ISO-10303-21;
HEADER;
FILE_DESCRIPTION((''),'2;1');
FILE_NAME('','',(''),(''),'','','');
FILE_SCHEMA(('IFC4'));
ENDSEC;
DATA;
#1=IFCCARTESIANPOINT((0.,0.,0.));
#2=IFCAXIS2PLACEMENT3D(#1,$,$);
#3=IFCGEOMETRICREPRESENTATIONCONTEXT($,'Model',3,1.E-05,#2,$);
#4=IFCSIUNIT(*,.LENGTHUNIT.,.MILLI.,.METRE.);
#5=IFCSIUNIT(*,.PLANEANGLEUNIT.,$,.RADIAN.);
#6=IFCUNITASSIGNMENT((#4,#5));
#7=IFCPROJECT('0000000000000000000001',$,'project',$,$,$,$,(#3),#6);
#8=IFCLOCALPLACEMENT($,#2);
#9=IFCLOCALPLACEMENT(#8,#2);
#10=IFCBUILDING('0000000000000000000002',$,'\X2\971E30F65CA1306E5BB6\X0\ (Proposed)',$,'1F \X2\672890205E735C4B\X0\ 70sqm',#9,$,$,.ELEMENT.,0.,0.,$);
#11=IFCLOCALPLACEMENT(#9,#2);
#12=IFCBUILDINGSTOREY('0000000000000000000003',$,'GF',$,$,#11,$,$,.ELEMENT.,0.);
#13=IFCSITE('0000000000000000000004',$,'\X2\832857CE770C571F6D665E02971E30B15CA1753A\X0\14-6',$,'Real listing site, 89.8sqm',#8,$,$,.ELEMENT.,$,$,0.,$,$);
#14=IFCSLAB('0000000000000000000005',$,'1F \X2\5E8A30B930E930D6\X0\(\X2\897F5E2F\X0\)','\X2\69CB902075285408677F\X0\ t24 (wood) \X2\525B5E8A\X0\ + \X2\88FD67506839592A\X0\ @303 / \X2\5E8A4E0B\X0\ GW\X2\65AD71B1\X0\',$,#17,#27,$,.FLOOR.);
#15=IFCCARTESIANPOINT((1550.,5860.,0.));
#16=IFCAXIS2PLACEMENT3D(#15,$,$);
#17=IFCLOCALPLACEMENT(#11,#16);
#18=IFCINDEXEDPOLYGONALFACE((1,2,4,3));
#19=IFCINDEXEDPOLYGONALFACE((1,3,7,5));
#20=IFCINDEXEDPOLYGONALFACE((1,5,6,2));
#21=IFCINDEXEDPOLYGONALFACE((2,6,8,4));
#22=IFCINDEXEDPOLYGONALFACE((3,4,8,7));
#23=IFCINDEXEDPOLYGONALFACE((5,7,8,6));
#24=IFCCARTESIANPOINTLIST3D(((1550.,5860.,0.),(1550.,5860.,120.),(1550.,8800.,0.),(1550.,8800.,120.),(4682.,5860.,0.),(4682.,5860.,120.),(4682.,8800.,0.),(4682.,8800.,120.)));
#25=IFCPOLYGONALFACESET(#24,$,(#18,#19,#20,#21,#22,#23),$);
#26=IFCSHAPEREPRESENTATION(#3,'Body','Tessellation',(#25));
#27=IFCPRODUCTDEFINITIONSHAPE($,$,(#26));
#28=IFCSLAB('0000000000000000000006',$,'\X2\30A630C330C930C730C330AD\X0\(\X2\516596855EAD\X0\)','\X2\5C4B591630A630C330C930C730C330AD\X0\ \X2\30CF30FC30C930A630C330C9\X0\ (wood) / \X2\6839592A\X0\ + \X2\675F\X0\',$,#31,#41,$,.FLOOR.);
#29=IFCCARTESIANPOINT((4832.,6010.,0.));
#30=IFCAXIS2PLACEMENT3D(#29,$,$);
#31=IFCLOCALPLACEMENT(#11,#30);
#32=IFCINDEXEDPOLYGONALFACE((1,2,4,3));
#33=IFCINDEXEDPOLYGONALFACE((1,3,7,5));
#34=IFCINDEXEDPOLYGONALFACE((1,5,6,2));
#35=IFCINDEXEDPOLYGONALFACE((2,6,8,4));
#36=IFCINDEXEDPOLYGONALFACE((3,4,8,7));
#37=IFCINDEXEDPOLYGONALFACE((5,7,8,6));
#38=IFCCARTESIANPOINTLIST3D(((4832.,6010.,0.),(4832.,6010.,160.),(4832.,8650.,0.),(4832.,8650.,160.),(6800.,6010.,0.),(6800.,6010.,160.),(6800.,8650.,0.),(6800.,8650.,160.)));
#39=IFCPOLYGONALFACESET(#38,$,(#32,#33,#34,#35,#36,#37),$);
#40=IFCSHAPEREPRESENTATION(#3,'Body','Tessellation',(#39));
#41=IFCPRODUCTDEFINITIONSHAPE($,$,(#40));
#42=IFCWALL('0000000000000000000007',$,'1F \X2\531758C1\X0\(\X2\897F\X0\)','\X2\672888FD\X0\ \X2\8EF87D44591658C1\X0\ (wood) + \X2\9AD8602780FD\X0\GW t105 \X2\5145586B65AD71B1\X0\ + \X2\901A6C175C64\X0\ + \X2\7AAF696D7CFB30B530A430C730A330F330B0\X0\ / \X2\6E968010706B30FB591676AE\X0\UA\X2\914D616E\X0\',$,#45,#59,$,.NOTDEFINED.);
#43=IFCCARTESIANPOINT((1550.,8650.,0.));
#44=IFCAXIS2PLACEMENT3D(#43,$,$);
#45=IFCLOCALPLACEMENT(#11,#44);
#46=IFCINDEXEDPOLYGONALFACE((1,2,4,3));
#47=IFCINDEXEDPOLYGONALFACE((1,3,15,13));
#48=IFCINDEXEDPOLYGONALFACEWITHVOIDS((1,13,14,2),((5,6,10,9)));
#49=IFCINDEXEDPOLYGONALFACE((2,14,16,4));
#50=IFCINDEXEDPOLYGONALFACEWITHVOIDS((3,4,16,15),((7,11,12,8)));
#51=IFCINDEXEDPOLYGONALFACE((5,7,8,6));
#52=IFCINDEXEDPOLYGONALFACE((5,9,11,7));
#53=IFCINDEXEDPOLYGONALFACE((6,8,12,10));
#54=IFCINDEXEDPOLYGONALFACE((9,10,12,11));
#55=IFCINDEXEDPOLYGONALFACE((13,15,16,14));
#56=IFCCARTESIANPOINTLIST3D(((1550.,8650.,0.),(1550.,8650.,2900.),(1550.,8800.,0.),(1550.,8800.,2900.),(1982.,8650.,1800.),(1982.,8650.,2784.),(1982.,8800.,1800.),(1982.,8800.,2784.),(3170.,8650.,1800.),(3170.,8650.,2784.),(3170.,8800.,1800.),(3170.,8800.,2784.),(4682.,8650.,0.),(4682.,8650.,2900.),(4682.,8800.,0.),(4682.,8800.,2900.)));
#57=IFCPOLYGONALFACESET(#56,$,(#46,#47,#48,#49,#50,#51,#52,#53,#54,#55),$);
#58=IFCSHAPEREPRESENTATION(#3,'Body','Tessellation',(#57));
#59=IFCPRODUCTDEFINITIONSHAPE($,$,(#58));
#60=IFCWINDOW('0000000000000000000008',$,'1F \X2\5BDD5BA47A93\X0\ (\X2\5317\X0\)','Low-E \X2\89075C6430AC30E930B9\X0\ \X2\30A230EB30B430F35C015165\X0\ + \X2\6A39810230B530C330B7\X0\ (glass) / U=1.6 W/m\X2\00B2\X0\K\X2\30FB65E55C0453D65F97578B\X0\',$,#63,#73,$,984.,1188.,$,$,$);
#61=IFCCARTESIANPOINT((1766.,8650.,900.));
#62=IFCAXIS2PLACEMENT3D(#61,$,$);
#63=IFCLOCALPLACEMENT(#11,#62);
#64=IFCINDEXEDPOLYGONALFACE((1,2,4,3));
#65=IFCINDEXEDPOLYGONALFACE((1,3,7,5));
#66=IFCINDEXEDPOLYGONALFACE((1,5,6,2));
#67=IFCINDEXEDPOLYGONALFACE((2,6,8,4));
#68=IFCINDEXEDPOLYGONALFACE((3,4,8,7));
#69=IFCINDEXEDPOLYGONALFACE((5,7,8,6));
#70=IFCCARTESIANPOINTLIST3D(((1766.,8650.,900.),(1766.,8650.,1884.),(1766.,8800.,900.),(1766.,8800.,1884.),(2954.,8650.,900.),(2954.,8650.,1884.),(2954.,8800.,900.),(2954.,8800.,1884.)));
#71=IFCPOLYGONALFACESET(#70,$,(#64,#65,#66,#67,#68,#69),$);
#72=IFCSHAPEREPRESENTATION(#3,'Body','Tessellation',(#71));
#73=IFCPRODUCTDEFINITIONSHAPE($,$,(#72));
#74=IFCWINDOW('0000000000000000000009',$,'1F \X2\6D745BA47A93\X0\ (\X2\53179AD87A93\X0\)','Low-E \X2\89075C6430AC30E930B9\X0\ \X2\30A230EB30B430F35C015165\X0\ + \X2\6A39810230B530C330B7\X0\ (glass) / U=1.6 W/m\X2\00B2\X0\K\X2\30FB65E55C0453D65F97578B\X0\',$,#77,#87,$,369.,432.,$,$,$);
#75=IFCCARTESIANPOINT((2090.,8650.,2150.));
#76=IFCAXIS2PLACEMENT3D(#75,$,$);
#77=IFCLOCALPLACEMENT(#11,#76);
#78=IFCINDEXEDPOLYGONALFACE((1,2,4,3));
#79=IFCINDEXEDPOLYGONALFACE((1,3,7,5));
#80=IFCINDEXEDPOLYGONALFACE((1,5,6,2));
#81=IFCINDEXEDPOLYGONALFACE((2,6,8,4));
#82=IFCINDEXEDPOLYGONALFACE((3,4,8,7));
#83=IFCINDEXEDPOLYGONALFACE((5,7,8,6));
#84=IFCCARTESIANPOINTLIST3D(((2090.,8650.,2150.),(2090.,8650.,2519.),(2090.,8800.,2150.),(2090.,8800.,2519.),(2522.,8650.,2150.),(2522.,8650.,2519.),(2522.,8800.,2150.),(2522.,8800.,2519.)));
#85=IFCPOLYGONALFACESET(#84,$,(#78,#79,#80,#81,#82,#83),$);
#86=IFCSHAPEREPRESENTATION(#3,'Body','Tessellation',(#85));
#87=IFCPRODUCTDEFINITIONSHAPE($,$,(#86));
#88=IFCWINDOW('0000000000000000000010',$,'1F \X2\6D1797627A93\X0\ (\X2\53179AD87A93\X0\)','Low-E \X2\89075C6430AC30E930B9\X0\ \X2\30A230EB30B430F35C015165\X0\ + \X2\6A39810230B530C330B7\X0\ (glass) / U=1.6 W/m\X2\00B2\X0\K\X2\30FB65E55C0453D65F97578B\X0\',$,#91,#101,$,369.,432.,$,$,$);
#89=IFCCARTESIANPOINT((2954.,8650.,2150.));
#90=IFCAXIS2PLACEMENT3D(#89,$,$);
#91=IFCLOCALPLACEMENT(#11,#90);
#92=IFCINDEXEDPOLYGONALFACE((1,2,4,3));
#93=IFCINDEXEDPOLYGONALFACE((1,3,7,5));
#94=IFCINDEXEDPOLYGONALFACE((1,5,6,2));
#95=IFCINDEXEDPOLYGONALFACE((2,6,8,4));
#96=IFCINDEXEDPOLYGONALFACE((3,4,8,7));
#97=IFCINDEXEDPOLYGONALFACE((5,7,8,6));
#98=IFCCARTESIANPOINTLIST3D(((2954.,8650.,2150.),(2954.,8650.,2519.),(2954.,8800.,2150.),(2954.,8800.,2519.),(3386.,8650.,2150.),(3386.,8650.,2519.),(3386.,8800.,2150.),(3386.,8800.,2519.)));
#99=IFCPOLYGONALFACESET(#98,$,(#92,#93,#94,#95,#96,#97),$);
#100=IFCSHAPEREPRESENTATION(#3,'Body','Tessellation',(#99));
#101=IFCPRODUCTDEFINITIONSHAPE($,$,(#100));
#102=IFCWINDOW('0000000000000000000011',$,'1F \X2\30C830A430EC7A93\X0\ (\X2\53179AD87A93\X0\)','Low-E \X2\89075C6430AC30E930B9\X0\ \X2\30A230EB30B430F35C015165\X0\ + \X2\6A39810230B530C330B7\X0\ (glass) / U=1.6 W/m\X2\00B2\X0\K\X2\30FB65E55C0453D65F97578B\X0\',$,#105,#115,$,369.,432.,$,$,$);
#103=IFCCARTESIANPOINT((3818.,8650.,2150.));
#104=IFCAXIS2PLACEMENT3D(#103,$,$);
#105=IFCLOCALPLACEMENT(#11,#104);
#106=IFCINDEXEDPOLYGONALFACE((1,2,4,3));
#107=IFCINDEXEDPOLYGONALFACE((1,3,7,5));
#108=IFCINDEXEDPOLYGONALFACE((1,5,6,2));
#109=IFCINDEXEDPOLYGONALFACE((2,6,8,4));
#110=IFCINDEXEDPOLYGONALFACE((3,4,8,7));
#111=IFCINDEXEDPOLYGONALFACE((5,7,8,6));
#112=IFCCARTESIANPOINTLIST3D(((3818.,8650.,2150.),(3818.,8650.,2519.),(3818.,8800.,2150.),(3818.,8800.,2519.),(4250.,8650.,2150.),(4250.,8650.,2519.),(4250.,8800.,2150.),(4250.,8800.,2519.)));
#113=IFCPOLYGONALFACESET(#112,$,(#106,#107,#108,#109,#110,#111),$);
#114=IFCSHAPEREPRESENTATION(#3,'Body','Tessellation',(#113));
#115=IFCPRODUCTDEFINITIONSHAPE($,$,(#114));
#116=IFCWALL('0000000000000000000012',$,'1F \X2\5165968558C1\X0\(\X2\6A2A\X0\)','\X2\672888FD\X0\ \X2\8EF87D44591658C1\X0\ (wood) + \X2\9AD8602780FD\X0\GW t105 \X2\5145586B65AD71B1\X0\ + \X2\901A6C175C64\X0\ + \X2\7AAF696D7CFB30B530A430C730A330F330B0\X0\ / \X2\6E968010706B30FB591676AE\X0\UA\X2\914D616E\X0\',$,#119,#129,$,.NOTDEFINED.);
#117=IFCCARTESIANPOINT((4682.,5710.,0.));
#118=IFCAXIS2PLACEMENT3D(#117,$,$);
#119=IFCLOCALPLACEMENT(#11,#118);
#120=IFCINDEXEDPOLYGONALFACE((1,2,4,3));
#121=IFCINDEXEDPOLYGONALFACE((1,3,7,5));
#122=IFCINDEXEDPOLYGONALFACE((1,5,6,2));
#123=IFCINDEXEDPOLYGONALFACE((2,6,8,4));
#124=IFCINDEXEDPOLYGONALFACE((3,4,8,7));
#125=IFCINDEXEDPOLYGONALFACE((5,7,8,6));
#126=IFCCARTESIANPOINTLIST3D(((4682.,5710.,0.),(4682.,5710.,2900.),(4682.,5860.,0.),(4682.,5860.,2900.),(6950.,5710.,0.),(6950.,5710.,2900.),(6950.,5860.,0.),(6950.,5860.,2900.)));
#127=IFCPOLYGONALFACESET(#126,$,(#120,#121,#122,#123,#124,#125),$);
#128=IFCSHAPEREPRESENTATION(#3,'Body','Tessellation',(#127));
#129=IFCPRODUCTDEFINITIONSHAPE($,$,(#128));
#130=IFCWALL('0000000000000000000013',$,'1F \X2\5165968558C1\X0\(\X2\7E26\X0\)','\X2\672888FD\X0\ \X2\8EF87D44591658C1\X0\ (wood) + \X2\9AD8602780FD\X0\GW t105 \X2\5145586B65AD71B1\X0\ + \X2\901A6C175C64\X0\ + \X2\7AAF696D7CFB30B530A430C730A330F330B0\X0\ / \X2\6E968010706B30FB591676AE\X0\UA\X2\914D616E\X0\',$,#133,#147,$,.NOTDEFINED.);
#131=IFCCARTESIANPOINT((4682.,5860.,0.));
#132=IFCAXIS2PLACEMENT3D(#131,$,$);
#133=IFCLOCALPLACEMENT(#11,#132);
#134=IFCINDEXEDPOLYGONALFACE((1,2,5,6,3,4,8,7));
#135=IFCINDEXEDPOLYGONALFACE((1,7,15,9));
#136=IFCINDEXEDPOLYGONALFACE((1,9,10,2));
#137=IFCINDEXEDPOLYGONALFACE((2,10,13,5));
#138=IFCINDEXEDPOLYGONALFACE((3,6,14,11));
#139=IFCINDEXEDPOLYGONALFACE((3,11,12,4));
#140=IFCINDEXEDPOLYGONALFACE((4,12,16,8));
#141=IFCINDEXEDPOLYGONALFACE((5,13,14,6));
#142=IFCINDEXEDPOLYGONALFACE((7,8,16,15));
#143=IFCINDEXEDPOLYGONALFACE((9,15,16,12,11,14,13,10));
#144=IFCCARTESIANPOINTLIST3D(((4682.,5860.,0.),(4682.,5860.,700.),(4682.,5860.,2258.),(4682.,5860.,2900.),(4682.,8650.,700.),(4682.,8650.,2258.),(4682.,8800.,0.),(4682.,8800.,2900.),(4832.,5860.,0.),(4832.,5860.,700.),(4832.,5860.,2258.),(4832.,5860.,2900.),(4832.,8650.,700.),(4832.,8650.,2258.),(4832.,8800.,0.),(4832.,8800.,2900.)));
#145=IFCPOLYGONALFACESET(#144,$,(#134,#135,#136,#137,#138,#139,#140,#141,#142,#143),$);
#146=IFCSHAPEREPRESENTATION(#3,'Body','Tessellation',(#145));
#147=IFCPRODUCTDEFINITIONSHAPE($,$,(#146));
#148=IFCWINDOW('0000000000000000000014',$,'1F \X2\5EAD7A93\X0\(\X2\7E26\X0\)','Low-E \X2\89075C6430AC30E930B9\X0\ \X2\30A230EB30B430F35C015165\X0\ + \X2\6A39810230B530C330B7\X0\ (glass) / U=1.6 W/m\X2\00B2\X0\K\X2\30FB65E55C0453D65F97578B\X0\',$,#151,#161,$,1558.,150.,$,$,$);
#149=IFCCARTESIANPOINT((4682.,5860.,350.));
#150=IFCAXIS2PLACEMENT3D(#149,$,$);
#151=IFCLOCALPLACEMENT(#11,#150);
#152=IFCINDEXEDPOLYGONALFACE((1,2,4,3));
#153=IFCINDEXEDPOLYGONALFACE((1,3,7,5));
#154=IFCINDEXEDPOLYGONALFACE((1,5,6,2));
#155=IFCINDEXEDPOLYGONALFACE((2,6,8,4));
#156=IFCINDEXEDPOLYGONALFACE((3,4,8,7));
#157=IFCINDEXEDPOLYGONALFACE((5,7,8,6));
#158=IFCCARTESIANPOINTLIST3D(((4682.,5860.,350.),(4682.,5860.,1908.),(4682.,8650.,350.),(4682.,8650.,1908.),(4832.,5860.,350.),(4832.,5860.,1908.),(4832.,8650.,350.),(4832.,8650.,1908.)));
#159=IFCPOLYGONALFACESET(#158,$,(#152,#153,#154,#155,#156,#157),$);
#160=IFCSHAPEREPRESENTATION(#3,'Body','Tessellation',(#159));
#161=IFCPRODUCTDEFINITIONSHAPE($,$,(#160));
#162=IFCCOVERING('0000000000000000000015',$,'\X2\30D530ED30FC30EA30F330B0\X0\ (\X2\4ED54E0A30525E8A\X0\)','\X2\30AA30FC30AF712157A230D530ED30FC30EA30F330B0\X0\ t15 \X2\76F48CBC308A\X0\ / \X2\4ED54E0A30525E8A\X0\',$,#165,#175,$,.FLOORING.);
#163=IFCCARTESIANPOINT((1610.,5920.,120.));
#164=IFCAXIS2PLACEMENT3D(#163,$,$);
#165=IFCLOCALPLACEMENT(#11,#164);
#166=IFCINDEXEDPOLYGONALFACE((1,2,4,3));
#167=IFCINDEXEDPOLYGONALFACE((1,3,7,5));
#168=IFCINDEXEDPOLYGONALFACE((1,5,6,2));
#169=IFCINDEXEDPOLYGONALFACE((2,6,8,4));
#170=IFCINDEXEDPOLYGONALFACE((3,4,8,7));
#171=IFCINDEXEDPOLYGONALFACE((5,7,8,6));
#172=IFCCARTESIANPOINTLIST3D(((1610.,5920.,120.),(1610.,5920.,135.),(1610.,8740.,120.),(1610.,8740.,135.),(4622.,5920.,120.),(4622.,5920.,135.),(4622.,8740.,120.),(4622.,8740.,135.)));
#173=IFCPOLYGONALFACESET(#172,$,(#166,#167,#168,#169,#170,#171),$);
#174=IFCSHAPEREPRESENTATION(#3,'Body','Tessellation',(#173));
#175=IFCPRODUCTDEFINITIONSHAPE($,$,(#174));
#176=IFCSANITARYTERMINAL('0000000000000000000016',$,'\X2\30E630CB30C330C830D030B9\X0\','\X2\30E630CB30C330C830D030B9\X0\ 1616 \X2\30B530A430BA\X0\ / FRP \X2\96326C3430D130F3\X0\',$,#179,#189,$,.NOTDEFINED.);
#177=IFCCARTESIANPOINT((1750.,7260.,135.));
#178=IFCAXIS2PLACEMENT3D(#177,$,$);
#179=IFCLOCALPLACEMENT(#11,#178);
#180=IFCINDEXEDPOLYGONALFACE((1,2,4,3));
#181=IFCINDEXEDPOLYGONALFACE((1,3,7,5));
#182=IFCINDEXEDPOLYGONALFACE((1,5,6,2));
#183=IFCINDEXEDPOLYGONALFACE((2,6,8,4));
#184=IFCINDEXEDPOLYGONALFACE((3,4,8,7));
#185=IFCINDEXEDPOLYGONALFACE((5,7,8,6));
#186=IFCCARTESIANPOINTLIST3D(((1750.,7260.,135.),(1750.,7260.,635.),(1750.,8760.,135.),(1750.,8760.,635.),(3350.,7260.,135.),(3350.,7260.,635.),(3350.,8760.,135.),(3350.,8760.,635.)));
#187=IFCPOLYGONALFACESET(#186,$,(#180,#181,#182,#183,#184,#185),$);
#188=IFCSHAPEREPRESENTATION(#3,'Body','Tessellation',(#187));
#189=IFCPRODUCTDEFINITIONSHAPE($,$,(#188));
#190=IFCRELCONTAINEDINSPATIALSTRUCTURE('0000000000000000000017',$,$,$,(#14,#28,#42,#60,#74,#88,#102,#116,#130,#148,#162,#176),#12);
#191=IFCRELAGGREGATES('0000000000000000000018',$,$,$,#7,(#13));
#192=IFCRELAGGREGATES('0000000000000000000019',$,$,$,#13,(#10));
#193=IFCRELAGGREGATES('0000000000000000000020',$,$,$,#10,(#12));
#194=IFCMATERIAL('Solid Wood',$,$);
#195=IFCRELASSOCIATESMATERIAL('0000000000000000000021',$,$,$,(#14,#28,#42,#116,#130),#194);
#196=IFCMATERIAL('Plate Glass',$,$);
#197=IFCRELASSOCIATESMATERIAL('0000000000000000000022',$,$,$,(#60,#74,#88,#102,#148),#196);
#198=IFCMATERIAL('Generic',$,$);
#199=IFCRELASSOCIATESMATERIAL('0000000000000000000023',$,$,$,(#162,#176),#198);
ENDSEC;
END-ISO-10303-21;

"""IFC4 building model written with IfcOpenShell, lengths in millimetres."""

from ifc_helpers import new_model, si_unit, frame, frame_2d, origin, place, context, project, spatial, rectangle, extrude, material, element, fill, save


model = new_model("IFC4")

# Units and contexts
model_context = context("Model", 3, precision=1e-05, world=origin())
ifc_project = project(units=[si_unit("LENGTHUNIT", "METRE", prefix="MILLI"), si_unit("PLANEANGLEUNIT", "RADIAN")], contexts=[model_context])

# Site, building, storey
site_placement = place(None, origin())
site = spatial("IfcSite", under=ifc_project, at=site_placement, Name="茨城県土浦市霞ケ岡町14-6", ObjectType="Real listing site, 89.8sqm", CompositionType="ELEMENT", RefElevation=0.0)
building_placement = place(site_placement, origin())
building = spatial("IfcBuilding", under=site, at=building_placement, Name="霞ヶ岡の家 (Proposed)", ObjectType="1F 木造平屋 70sqm", CompositionType="ELEMENT", ElevationOfRefHeight=0.0, ElevationOfTerrain=0.0)
storey_placement = place(building_placement, origin())
storey = spatial("IfcBuildingStorey", under=building, at=storey_placement, Name="GF", CompositionType="ELEMENT", Elevation=0.0)

# Slabs
ifc_material_1 = material(Name="Solid Wood")
slab_1_placement = place(storey_placement, frame((1550.0, 5860.0, 0.0)))
element("IfcSlab", 1, at=slab_1_placement, inside=storey, material=ifc_material_1, Name="1F 床スラブ(西帯)", Description="構造用合板 t24 (wood) 剛床 + 製材根太 @303 / 床下 GW断熱", PredefinedType="FLOOR", context=model_context, shape_type="SweptSolid", body=[
    extrude(rectangle(XDim=3132.0, YDim=2940.0, at=frame_2d((1566.0, 1470.0))), frame((1550.0, 5860.0, 0.0)), (0.0, 0.0, 1.0), 120.0),
])
slab_2_placement = place(storey_placement, frame((4832.0, 6010.0, 0.0)))
element("IfcSlab", 2, at=slab_2_placement, inside=storey, material=ifc_material_1, Name="ウッドデッキ(入隅庭)", Description="屋外ウッドデッキ ハードウッド (wood) / 根太 + 束", PredefinedType="FLOOR", context=model_context, shape_type="SweptSolid", body=[
    extrude(rectangle(XDim=1968.0, YDim=2640.0, at=frame_2d((984.0, 1320.0))), frame((4832.0, 6010.0, 0.0)), (0.0, 0.0, 1.0), 160.0),
])

# Wall, openings, windows
wall_1_placement = place(storey_placement, frame((1550.0, 8650.0, 0.0)))
wall_1 = element("IfcWall", 3, at=wall_1_placement, inside=storey, material=ifc_material_1, Name="1F 北壁(西)", Description="木製 軸組外壁 (wood) + 高性能GW t105 充填断熱 + 通気層 + 窯業系サイディング / 準耐火・外皮UA配慮", PredefinedType="NOTDEFINED", context=model_context, shape_type="SweptSolid", body=[
    extrude(rectangle(XDim=3132.0, YDim=150.0, at=frame_2d((1566.0, 75.0))), frame((1550.0, 8650.0, 0.0)), (0.0, 0.0, 1.0), 2900.0),
])
opening_1_placement = place(storey_placement, frame((1766.0, 8650.0, 900.0)))
opening_1 = element("IfcOpeningElement", 4, at=opening_1_placement, cuts=wall_1, PredefinedType="NOTDEFINED", context=model_context, shape_type="SweptSolid", body=[
    extrude(rectangle(XDim=1188.0, YDim=150.0, at=frame_2d((594.0, 75.0))), frame((1766.0, 8650.0, 900.0)), (0.0, 0.0, 1.0), 984.0),
])
opening_2_placement = place(storey_placement, frame((2090.0, 8650.0, 2150.0)))
opening_2 = element("IfcOpeningElement", 5, at=opening_2_placement, cuts=wall_1, PredefinedType="NOTDEFINED", context=model_context, shape_type="SweptSolid", body=[
    extrude(rectangle(XDim=432.0, YDim=150.0, at=frame_2d((216.0, 75.0))), frame((2090.0, 8650.0, 2150.0)), (0.0, 0.0, 1.0), 369.0),
])
opening_3_placement = place(storey_placement, frame((2954.0, 8650.0, 2150.0)))
opening_3 = element("IfcOpeningElement", 6, at=opening_3_placement, cuts=wall_1, PredefinedType="NOTDEFINED", context=model_context, shape_type="SweptSolid", body=[
    extrude(rectangle(XDim=432.0, YDim=150.0, at=frame_2d((216.0, 75.0))), frame((2954.0, 8650.0, 2150.0)), (0.0, 0.0, 1.0), 369.0),
])
opening_4_placement = place(storey_placement, frame((3818.0, 8650.0, 2150.0)))
opening_4 = element("IfcOpeningElement", 7, at=opening_4_placement, cuts=wall_1, PredefinedType="NOTDEFINED", context=model_context, shape_type="SweptSolid", body=[
    extrude(rectangle(XDim=432.0, YDim=150.0, at=frame_2d((216.0, 75.0))), frame((3818.0, 8650.0, 2150.0)), (0.0, 0.0, 1.0), 369.0),
])
ifc_material_2 = material(Name="Plate Glass")
window_1_placement = place(storey_placement, frame((1766.0, 8650.0, 900.0)))
window_1 = element("IfcWindow", 8, at=window_1_placement, inside=storey, material=ifc_material_2, Name="1F 寝室窓 (北)", Description="Low-E 複層ガラス アルゴン封入 + 樹脂サッシ (glass) / U=1.6 W/m²K・日射取得型", OverallHeight=984.0, OverallWidth=1188.0, context=model_context, shape_type="SweptSolid", body=[
    extrude(rectangle(XDim=1188.0, YDim=150.0, at=frame_2d((594.0, 75.0))), frame((1766.0, 8650.0, 900.0)), (0.0, 0.0, 1.0), 984.0),
])
fill(opening_1, window_1)
window_2_placement = place(storey_placement, frame((2090.0, 8650.0, 2150.0)))
window_2 = element("IfcWindow", 9, at=window_2_placement, inside=storey, material=ifc_material_2, Name="1F 浴室窓 (北高窓)", Description="Low-E 複層ガラス アルゴン封入 + 樹脂サッシ (glass) / U=1.6 W/m²K・日射取得型", OverallHeight=369.0, OverallWidth=432.0, context=model_context, shape_type="SweptSolid", body=[
    extrude(rectangle(XDim=432.0, YDim=150.0, at=frame_2d((216.0, 75.0))), frame((2090.0, 8650.0, 2150.0)), (0.0, 0.0, 1.0), 369.0),
])
fill(opening_2, window_2)
window_3_placement = place(storey_placement, frame((2954.0, 8650.0, 2150.0)))
window_3 = element("IfcWindow", 10, at=window_3_placement, inside=storey, material=ifc_material_2, Name="1F 洗面窓 (北高窓)", Description="Low-E 複層ガラス アルゴン封入 + 樹脂サッシ (glass) / U=1.6 W/m²K・日射取得型", OverallHeight=369.0, OverallWidth=432.0, context=model_context, shape_type="SweptSolid", body=[
    extrude(rectangle(XDim=432.0, YDim=150.0, at=frame_2d((216.0, 75.0))), frame((2954.0, 8650.0, 2150.0)), (0.0, 0.0, 1.0), 369.0),
])
fill(opening_3, window_3)
window_4_placement = place(storey_placement, frame((3818.0, 8650.0, 2150.0)))
window_4 = element("IfcWindow", 11, at=window_4_placement, inside=storey, material=ifc_material_2, Name="1F トイレ窓 (北高窓)", Description="Low-E 複層ガラス アルゴン封入 + 樹脂サッシ (glass) / U=1.6 W/m²K・日射取得型", OverallHeight=369.0, OverallWidth=432.0, context=model_context, shape_type="SweptSolid", body=[
    extrude(rectangle(XDim=432.0, YDim=150.0, at=frame_2d((216.0, 75.0))), frame((3818.0, 8650.0, 2150.0)), (0.0, 0.0, 1.0), 369.0),
])
fill(opening_4, window_4)

# Wall
wall_2_placement = place(storey_placement, frame((4682.0, 5710.0, 0.0)))
element("IfcWall", 12, at=wall_2_placement, inside=storey, material=ifc_material_1, Name="1F 入隅壁(横)", Description="木製 軸組外壁 (wood) + 高性能GW t105 充填断熱 + 通気層 + 窯業系サイディング / 準耐火・外皮UA配慮", PredefinedType="NOTDEFINED", context=model_context, shape_type="SweptSolid", body=[
    extrude(rectangle(XDim=2268.0, YDim=150.0, at=frame_2d((1134.0, 75.0))), frame((4682.0, 5710.0, 0.0)), (0.0, 0.0, 1.0), 2900.0),
])

# Wall, opening, window
wall_3_placement = place(storey_placement, frame((4682.0, 5860.0, 0.0)))
wall_3 = element("IfcWall", 13, at=wall_3_placement, inside=storey, material=ifc_material_1, Name="1F 入隅壁(縦)", Description="木製 軸組外壁 (wood) + 高性能GW t105 充填断熱 + 通気層 + 窯業系サイディング / 準耐火・外皮UA配慮", PredefinedType="NOTDEFINED", context=model_context, shape_type="SweptSolid", body=[
    extrude(rectangle(XDim=150.0, YDim=2940.0, at=frame_2d((75.0, 1470.0))), frame((4682.0, 5860.0, 0.0)), (0.0, 0.0, 1.0), 2900.0),
])
opening_5_placement = place(storey_placement, frame((4682.0, 5860.0, 350.0)))
opening_5 = element("IfcOpeningElement", 14, at=opening_5_placement, cuts=wall_3, PredefinedType="NOTDEFINED", context=model_context, shape_type="SweptSolid", body=[
    extrude(rectangle(XDim=150.0, YDim=2790.0, at=frame_2d((75.0, 1395.0))), frame((4682.0, 5860.0, 350.0)), (0.0, 0.0, 1.0), 1558.0),
])
window_5_placement = place(storey_placement, frame((4682.0, 5860.0, 350.0)))
window_5 = element("IfcWindow", 15, at=window_5_placement, inside=storey, material=ifc_material_2, Name="1F 庭窓(縦)", Description="Low-E 複層ガラス アルゴン封入 + 樹脂サッシ (glass) / U=1.6 W/m²K・日射取得型", OverallHeight=1558.0, OverallWidth=150.0, context=model_context, shape_type="SweptSolid", body=[
    extrude(rectangle(XDim=150.0, YDim=2790.0, at=frame_2d((75.0, 1395.0))), frame((4682.0, 5860.0, 350.0)), (0.0, 0.0, 1.0), 1558.0),
])
fill(opening_5, window_5)

# Covering
ifc_material_3 = material(Name="Generic")
covering_placement = place(storey_placement, frame((1610.0, 5920.0, 120.0)))
element("IfcCovering", 16, at=covering_placement, inside=storey, material=ifc_material_3, Name="フローリング (仕上げ床)", Description="オーク無垢フローリング t15 直貼り / 仕上げ床", PredefinedType="FLOORING", context=model_context, shape_type="SweptSolid", body=[
    extrude(rectangle(XDim=3012.0, YDim=2820.0, at=frame_2d((1506.0, 1410.0))), frame((1610.0, 5920.0, 120.0)), (0.0, 0.0, 1.0), 15.0),
])

# Sanitary terminal
sanitary_terminal_1_placement = place(storey_placement, frame((1750.0, 7260.0, 135.0)))
element("IfcSanitaryTerminal", 17, at=sanitary_terminal_1_placement, inside=storey, material=ifc_material_3, Name="ユニットバス", Description="ユニットバス 1616 サイズ / FRP 防水パン", PredefinedType="NOTDEFINED", context=model_context, shape_type="SweptSolid", body=[
    extrude(rectangle(XDim=1600.0, YDim=1500.0, at=frame_2d((800.0, 750.0))), frame((1750.0, 7260.0, 135.0)), (0.0, 0.0, 1.0), 500.0),
])

save(model, "model.ifc")
